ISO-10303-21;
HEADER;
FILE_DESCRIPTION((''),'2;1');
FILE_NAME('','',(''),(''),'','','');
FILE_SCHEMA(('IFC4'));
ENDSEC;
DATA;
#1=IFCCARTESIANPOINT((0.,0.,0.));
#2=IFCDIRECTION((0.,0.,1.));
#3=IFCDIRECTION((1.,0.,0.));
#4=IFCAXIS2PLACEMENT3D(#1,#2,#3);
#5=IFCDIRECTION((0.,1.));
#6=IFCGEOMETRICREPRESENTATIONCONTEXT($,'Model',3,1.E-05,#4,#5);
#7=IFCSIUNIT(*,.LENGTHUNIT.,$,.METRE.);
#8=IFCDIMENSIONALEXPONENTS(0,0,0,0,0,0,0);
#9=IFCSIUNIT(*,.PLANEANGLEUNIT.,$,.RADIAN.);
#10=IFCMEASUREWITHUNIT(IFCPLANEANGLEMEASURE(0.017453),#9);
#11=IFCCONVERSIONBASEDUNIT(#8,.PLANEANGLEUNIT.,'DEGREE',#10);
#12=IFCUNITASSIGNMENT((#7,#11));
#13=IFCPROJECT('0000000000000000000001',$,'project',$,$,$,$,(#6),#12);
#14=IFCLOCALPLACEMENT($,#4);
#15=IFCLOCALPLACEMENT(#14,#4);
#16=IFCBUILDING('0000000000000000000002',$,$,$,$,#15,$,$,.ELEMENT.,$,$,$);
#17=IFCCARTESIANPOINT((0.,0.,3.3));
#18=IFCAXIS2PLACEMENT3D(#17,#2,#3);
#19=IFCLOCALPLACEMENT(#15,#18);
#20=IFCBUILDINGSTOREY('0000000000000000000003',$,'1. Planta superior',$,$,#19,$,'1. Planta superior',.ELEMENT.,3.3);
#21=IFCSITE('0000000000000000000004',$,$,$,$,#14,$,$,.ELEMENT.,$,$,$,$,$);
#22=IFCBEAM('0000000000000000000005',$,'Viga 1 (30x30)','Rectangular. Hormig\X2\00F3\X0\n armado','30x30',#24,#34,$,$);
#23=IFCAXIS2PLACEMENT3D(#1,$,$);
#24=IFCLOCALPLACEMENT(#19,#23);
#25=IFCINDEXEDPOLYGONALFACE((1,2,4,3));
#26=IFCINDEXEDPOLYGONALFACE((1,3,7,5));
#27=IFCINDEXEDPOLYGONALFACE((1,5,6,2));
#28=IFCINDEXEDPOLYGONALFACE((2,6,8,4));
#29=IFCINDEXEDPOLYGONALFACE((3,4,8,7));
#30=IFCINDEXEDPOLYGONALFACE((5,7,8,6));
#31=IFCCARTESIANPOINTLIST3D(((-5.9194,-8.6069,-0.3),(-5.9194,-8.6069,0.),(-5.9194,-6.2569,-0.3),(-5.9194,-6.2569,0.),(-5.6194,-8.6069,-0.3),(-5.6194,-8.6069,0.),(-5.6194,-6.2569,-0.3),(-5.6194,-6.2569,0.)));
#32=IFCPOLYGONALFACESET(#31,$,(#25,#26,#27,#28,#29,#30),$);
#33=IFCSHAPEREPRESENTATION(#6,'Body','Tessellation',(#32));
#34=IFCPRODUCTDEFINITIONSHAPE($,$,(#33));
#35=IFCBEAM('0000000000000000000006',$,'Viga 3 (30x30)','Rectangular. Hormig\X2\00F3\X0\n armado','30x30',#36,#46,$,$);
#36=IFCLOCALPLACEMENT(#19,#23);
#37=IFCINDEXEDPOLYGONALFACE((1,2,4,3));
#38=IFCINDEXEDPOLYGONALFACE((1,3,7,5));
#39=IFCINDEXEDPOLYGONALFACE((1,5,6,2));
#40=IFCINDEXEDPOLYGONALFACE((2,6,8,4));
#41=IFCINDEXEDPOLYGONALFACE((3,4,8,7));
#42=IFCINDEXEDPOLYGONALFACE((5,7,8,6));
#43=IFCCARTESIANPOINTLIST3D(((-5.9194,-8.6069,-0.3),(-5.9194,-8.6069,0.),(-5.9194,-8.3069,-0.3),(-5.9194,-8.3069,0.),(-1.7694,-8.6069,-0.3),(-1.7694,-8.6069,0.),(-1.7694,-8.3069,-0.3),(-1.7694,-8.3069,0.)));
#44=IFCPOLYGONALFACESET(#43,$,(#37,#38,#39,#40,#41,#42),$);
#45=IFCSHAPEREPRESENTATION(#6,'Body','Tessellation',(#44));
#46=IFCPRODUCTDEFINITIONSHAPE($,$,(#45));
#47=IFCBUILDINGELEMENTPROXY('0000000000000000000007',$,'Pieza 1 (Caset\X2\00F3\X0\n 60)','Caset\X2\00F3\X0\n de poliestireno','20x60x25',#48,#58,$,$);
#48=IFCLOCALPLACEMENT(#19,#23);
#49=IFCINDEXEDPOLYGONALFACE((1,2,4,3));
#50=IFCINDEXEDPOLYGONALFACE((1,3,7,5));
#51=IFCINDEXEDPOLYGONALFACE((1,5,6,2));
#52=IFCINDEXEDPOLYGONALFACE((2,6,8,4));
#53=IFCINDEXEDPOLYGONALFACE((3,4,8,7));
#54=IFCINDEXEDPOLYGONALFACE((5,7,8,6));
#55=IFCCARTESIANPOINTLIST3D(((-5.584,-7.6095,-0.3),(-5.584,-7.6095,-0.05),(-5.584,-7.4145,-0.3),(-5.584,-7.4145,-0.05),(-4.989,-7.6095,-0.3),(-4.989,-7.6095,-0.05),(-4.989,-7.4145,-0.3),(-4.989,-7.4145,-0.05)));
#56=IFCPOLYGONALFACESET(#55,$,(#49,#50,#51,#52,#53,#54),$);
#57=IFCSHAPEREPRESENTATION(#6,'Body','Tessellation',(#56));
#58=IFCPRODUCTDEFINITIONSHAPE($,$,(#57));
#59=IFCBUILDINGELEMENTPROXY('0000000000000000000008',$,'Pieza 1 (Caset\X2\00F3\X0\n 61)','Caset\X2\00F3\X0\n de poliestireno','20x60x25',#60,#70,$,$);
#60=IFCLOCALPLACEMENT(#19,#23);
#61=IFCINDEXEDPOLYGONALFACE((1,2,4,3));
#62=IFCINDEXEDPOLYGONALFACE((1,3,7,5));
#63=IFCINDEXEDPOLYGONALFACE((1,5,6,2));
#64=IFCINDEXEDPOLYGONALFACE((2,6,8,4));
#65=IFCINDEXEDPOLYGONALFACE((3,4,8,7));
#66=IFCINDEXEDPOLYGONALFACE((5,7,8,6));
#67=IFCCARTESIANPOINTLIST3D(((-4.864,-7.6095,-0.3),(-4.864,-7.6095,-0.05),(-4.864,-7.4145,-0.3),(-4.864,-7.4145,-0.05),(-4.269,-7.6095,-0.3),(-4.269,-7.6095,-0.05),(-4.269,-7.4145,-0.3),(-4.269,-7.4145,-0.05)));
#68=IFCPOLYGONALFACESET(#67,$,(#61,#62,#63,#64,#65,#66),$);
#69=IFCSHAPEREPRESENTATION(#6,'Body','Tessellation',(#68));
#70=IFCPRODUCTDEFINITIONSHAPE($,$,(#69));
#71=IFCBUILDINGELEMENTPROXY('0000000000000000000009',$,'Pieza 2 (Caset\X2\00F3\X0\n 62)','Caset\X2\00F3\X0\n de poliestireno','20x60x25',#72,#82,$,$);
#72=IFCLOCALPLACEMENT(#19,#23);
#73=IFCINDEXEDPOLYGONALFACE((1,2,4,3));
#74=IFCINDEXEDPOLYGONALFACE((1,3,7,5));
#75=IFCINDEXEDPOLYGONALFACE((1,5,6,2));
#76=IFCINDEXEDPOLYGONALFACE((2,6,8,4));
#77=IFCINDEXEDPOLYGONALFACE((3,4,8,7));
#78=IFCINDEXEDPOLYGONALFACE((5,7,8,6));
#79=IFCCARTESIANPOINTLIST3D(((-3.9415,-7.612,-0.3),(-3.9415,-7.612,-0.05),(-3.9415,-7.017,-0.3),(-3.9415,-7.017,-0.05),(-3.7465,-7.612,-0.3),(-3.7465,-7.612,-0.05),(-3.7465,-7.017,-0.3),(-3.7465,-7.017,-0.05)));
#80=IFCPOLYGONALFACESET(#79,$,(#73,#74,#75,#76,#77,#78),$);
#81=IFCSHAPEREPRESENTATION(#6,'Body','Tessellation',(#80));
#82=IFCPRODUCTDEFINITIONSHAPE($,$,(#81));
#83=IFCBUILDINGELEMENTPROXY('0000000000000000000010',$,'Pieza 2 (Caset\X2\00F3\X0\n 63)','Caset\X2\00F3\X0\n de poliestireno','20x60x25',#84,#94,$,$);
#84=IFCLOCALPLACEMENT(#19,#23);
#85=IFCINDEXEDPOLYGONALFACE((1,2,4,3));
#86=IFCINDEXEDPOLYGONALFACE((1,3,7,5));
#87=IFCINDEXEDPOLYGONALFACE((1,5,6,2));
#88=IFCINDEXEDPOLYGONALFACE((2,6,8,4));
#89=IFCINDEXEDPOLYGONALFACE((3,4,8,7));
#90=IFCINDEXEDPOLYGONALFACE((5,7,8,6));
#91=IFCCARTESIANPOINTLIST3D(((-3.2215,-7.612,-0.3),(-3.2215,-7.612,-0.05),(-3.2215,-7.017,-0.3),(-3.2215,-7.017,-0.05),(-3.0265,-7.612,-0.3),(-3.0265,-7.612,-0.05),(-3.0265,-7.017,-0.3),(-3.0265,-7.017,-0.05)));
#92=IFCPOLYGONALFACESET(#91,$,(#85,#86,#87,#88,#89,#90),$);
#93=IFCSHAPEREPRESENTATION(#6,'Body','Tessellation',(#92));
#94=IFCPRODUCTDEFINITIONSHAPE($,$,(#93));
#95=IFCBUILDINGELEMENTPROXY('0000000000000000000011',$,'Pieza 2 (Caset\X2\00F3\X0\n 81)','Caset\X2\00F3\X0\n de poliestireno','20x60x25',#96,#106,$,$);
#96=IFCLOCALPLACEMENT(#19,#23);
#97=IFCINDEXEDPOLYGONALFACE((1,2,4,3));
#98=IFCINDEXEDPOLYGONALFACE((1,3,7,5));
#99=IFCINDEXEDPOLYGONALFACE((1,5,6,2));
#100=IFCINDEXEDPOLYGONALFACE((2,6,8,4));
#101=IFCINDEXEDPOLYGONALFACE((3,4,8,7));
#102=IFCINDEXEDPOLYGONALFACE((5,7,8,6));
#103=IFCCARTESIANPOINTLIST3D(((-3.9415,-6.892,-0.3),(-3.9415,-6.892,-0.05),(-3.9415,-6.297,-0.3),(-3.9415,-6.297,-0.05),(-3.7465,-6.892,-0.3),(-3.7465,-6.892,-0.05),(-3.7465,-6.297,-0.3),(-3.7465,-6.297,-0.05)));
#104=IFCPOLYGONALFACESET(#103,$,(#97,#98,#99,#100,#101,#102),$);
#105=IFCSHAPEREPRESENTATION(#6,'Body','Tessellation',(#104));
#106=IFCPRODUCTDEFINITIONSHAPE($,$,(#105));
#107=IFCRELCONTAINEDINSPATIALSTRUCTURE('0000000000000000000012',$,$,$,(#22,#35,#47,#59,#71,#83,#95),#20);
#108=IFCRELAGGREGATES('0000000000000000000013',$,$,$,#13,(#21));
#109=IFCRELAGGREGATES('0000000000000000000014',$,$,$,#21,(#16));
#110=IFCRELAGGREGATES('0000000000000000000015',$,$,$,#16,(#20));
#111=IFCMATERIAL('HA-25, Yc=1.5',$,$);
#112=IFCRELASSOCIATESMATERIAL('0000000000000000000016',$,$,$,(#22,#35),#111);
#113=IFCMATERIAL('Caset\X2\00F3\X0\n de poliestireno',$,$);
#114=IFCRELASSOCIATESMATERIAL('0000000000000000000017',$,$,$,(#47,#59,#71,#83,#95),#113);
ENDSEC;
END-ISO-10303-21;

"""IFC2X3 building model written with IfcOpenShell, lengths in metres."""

from ifc_helpers import new_model, entity, si_unit, converted_unit, direction, frame, frame_2d, origin_with_axes, origin_2d_with_axis, place, context, project, spatial, rectangle, extrude, source, transform, mapped, material, element, save


model = new_model("IFC2X3")

# Units and contexts
model_context = context("Model", 3, precision=1e-05, world=origin_with_axes(), true_north=direction((0.0, 1.0)))
ifc_project = project(units=[si_unit("LENGTHUNIT", "METRE"), converted_unit("PLANEANGLEUNIT", "DEGREE", entity("IfcPlaneAngleMeasure", 0.017453), si_unit("PLANEANGLEUNIT", "RADIAN"), dimensions=[0, 0, 0, 0, 0, 0, 0])], contexts=[model_context])

# Site, building, storey
site_placement = place(None, origin_with_axes())
site = spatial("IfcSite", under=ifc_project, at=site_placement, CompositionType="ELEMENT")
building_placement = place(site_placement, origin_with_axes())
building = spatial("IfcBuilding", under=site, at=building_placement, CompositionType="ELEMENT")
storey_placement = place(building_placement, frame((0.0, 0.0, 3.3), z_axis=(0.0, 0.0, 1.0), x_axis=(1.0, 0.0, 0.0)))
storey = spatial("IfcBuildingStorey", under=building, at=storey_placement, Name="1. Planta superior", LongName="1. Planta superior", CompositionType="ELEMENT", Elevation=3.3)

# Beams
ifc_material_1 = material(Name="HA-25, Yc=1.5")
beam_1_placement = place(storey_placement, frame((-5.7694, -8.6069, 0.0), z_axis=(0.0, 1.0, 0.0), x_axis=(-1.0, 0.0, 0.0)))
element("IfcBeam", 1, at=beam_1_placement, inside=storey, material=ifc_material_1, Name="Viga 1 (30x30)", Description="Rectangular. Hormigón armado", ObjectType="30x30", context=model_context, shape_type="SweptSolid", body=[
    extrude(rectangle(XDim=0.3, YDim=0.3, at=frame_2d((0.0, -0.15), x_axis=(1.0, 0.0))), origin_with_axes(), (0.0, 0.0, 1.0), 2.35),
])
beam_2_placement = place(storey_placement, frame((-5.9194, -8.4569, 0.0), z_axis=(1.0, 0.0, 0.0), x_axis=(0.0, 1.0, 0.0)))
element("IfcBeam", 2, at=beam_2_placement, inside=storey, material=ifc_material_1, Name="Viga 3 (30x30)", Description="Rectangular. Hormigón armado", ObjectType="30x30", context=model_context, shape_type="SweptSolid", body=[
    extrude(rectangle(XDim=0.3, YDim=0.3, at=frame_2d((0.0, -0.15), x_axis=(1.0, 0.0))), origin_with_axes(), (0.0, 0.0, 1.0), 4.15),
])

# Building element proxies
ifc_material_2 = material(Name="Casetón de poliestireno")
shared_shape = source(origin_with_axes(), model_context, "Body", "SweptSolid", [
    extrude(rectangle(XDim=0.195, YDim=0.25, at=origin_2d_with_axis()), origin_with_axes(), (0.0, 0.0, 1.0), 0.595),
])
placement_1 = place(storey_placement, frame((-5.584, -7.512, -0.175), z_axis=(1.0, 0.0, 0.0), x_axis=(0.0, 1.0, 0.0)))
proxy_1_placement = place(placement_1, origin_with_axes())
element("IfcBuildingElementProxy", 3, at=proxy_1_placement, inside=storey, material=ifc_material_2, Name="Pieza 1 (Casetón 60)", Description="Casetón de poliestireno", ObjectType="20x60x25", context=model_context, shape_type="MappedRepresentation", body=[
    mapped(shared_shape, transform((0.0, 0.0, 0.0), x_axis=(1.0, 0.0, 0.0), y_axis=(0.0, 1.0, 0.0), z_axis=(0.0, 0.0, 1.0))),
])
placement_2 = place(storey_placement, frame((-4.864, -7.512, -0.175), z_axis=(1.0, 0.0, 0.0), x_axis=(0.0, 1.0, 0.0)))
proxy_2_placement = place(placement_2, origin_with_axes())
element("IfcBuildingElementProxy", 4, at=proxy_2_placement, inside=storey, material=ifc_material_2, Name="Pieza 1 (Casetón 61)", Description="Casetón de poliestireno", ObjectType="20x60x25", context=model_context, shape_type="MappedRepresentation", body=[
    mapped(shared_shape, transform((0.0, 0.0, 0.0), x_axis=(1.0, 0.0, 0.0), y_axis=(0.0, 1.0, 0.0), z_axis=(0.0, 0.0, 1.0))),
])
placement_3 = place(storey_placement, frame((-3.844, -7.612, -0.175), z_axis=(0.0, 1.0, 0.0), x_axis=(-1.0, 0.0, 0.0)))
for number, where, z_axis, x_axis, name in (
    (5, (0.0, 0.0, 0.0), (0.0, 0.0, 1.0), (1.0, 0.0, 0.0), "Pieza 2 (Casetón 62)"),
):
    element("IfcBuildingElementProxy", number, at=place(placement_3, frame(where, z_axis=z_axis, x_axis=x_axis)), inside=storey, material=ifc_material_2, Name=name, Description="Casetón de poliestireno", ObjectType="20x60x25", context=model_context, shape_type="MappedRepresentation", body=[
        mapped(shared_shape, transform((0.0, 0.0, 0.0), x_axis=(1.0, 0.0, 0.0), y_axis=(0.0, 1.0, 0.0), z_axis=(0.0, 0.0, 1.0))),
    ])
placement_4 = place(storey_placement, frame((-3.124, -7.612, -0.175), z_axis=(0.0, 1.0, 0.0), x_axis=(-1.0, 0.0, 0.0)))
for number, where, z_axis, x_axis, name in (
    (6, (0.0, 0.0, 0.0), (0.0, 0.0, 1.0), (1.0, 0.0, 0.0), "Pieza 2 (Casetón 63)"),
):
    element("IfcBuildingElementProxy", number, at=place(placement_4, frame(where, z_axis=z_axis, x_axis=x_axis)), inside=storey, material=ifc_material_2, Name=name, Description="Casetón de poliestireno", ObjectType="20x60x25", context=model_context, shape_type="MappedRepresentation", body=[
        mapped(shared_shape, transform((0.0, 0.0, 0.0), x_axis=(1.0, 0.0, 0.0), y_axis=(0.0, 1.0, 0.0), z_axis=(0.0, 0.0, 1.0))),
    ])
placement_5 = place(storey_placement, frame((-3.844, -6.892, -0.175), z_axis=(0.0, 1.0, 0.0), x_axis=(-1.0, 0.0, 0.0)))
for number, where, z_axis, x_axis, name in (
    (7, (0.0, 0.0, 0.0), (0.0, 0.0, 1.0), (1.0, 0.0, 0.0), "Pieza 2 (Casetón 81)"),
):
    element("IfcBuildingElementProxy", number, at=place(placement_5, frame(where, z_axis=z_axis, x_axis=x_axis)), inside=storey, material=ifc_material_2, Name=name, Description="Casetón de poliestireno", ObjectType="20x60x25", context=model_context, shape_type="MappedRepresentation", body=[
        mapped(shared_shape, transform((0.0, 0.0, 0.0), x_axis=(1.0, 0.0, 0.0), y_axis=(0.0, 1.0, 0.0), z_axis=(0.0, 0.0, 1.0))),
    ])

save(model, "model.ifc")
